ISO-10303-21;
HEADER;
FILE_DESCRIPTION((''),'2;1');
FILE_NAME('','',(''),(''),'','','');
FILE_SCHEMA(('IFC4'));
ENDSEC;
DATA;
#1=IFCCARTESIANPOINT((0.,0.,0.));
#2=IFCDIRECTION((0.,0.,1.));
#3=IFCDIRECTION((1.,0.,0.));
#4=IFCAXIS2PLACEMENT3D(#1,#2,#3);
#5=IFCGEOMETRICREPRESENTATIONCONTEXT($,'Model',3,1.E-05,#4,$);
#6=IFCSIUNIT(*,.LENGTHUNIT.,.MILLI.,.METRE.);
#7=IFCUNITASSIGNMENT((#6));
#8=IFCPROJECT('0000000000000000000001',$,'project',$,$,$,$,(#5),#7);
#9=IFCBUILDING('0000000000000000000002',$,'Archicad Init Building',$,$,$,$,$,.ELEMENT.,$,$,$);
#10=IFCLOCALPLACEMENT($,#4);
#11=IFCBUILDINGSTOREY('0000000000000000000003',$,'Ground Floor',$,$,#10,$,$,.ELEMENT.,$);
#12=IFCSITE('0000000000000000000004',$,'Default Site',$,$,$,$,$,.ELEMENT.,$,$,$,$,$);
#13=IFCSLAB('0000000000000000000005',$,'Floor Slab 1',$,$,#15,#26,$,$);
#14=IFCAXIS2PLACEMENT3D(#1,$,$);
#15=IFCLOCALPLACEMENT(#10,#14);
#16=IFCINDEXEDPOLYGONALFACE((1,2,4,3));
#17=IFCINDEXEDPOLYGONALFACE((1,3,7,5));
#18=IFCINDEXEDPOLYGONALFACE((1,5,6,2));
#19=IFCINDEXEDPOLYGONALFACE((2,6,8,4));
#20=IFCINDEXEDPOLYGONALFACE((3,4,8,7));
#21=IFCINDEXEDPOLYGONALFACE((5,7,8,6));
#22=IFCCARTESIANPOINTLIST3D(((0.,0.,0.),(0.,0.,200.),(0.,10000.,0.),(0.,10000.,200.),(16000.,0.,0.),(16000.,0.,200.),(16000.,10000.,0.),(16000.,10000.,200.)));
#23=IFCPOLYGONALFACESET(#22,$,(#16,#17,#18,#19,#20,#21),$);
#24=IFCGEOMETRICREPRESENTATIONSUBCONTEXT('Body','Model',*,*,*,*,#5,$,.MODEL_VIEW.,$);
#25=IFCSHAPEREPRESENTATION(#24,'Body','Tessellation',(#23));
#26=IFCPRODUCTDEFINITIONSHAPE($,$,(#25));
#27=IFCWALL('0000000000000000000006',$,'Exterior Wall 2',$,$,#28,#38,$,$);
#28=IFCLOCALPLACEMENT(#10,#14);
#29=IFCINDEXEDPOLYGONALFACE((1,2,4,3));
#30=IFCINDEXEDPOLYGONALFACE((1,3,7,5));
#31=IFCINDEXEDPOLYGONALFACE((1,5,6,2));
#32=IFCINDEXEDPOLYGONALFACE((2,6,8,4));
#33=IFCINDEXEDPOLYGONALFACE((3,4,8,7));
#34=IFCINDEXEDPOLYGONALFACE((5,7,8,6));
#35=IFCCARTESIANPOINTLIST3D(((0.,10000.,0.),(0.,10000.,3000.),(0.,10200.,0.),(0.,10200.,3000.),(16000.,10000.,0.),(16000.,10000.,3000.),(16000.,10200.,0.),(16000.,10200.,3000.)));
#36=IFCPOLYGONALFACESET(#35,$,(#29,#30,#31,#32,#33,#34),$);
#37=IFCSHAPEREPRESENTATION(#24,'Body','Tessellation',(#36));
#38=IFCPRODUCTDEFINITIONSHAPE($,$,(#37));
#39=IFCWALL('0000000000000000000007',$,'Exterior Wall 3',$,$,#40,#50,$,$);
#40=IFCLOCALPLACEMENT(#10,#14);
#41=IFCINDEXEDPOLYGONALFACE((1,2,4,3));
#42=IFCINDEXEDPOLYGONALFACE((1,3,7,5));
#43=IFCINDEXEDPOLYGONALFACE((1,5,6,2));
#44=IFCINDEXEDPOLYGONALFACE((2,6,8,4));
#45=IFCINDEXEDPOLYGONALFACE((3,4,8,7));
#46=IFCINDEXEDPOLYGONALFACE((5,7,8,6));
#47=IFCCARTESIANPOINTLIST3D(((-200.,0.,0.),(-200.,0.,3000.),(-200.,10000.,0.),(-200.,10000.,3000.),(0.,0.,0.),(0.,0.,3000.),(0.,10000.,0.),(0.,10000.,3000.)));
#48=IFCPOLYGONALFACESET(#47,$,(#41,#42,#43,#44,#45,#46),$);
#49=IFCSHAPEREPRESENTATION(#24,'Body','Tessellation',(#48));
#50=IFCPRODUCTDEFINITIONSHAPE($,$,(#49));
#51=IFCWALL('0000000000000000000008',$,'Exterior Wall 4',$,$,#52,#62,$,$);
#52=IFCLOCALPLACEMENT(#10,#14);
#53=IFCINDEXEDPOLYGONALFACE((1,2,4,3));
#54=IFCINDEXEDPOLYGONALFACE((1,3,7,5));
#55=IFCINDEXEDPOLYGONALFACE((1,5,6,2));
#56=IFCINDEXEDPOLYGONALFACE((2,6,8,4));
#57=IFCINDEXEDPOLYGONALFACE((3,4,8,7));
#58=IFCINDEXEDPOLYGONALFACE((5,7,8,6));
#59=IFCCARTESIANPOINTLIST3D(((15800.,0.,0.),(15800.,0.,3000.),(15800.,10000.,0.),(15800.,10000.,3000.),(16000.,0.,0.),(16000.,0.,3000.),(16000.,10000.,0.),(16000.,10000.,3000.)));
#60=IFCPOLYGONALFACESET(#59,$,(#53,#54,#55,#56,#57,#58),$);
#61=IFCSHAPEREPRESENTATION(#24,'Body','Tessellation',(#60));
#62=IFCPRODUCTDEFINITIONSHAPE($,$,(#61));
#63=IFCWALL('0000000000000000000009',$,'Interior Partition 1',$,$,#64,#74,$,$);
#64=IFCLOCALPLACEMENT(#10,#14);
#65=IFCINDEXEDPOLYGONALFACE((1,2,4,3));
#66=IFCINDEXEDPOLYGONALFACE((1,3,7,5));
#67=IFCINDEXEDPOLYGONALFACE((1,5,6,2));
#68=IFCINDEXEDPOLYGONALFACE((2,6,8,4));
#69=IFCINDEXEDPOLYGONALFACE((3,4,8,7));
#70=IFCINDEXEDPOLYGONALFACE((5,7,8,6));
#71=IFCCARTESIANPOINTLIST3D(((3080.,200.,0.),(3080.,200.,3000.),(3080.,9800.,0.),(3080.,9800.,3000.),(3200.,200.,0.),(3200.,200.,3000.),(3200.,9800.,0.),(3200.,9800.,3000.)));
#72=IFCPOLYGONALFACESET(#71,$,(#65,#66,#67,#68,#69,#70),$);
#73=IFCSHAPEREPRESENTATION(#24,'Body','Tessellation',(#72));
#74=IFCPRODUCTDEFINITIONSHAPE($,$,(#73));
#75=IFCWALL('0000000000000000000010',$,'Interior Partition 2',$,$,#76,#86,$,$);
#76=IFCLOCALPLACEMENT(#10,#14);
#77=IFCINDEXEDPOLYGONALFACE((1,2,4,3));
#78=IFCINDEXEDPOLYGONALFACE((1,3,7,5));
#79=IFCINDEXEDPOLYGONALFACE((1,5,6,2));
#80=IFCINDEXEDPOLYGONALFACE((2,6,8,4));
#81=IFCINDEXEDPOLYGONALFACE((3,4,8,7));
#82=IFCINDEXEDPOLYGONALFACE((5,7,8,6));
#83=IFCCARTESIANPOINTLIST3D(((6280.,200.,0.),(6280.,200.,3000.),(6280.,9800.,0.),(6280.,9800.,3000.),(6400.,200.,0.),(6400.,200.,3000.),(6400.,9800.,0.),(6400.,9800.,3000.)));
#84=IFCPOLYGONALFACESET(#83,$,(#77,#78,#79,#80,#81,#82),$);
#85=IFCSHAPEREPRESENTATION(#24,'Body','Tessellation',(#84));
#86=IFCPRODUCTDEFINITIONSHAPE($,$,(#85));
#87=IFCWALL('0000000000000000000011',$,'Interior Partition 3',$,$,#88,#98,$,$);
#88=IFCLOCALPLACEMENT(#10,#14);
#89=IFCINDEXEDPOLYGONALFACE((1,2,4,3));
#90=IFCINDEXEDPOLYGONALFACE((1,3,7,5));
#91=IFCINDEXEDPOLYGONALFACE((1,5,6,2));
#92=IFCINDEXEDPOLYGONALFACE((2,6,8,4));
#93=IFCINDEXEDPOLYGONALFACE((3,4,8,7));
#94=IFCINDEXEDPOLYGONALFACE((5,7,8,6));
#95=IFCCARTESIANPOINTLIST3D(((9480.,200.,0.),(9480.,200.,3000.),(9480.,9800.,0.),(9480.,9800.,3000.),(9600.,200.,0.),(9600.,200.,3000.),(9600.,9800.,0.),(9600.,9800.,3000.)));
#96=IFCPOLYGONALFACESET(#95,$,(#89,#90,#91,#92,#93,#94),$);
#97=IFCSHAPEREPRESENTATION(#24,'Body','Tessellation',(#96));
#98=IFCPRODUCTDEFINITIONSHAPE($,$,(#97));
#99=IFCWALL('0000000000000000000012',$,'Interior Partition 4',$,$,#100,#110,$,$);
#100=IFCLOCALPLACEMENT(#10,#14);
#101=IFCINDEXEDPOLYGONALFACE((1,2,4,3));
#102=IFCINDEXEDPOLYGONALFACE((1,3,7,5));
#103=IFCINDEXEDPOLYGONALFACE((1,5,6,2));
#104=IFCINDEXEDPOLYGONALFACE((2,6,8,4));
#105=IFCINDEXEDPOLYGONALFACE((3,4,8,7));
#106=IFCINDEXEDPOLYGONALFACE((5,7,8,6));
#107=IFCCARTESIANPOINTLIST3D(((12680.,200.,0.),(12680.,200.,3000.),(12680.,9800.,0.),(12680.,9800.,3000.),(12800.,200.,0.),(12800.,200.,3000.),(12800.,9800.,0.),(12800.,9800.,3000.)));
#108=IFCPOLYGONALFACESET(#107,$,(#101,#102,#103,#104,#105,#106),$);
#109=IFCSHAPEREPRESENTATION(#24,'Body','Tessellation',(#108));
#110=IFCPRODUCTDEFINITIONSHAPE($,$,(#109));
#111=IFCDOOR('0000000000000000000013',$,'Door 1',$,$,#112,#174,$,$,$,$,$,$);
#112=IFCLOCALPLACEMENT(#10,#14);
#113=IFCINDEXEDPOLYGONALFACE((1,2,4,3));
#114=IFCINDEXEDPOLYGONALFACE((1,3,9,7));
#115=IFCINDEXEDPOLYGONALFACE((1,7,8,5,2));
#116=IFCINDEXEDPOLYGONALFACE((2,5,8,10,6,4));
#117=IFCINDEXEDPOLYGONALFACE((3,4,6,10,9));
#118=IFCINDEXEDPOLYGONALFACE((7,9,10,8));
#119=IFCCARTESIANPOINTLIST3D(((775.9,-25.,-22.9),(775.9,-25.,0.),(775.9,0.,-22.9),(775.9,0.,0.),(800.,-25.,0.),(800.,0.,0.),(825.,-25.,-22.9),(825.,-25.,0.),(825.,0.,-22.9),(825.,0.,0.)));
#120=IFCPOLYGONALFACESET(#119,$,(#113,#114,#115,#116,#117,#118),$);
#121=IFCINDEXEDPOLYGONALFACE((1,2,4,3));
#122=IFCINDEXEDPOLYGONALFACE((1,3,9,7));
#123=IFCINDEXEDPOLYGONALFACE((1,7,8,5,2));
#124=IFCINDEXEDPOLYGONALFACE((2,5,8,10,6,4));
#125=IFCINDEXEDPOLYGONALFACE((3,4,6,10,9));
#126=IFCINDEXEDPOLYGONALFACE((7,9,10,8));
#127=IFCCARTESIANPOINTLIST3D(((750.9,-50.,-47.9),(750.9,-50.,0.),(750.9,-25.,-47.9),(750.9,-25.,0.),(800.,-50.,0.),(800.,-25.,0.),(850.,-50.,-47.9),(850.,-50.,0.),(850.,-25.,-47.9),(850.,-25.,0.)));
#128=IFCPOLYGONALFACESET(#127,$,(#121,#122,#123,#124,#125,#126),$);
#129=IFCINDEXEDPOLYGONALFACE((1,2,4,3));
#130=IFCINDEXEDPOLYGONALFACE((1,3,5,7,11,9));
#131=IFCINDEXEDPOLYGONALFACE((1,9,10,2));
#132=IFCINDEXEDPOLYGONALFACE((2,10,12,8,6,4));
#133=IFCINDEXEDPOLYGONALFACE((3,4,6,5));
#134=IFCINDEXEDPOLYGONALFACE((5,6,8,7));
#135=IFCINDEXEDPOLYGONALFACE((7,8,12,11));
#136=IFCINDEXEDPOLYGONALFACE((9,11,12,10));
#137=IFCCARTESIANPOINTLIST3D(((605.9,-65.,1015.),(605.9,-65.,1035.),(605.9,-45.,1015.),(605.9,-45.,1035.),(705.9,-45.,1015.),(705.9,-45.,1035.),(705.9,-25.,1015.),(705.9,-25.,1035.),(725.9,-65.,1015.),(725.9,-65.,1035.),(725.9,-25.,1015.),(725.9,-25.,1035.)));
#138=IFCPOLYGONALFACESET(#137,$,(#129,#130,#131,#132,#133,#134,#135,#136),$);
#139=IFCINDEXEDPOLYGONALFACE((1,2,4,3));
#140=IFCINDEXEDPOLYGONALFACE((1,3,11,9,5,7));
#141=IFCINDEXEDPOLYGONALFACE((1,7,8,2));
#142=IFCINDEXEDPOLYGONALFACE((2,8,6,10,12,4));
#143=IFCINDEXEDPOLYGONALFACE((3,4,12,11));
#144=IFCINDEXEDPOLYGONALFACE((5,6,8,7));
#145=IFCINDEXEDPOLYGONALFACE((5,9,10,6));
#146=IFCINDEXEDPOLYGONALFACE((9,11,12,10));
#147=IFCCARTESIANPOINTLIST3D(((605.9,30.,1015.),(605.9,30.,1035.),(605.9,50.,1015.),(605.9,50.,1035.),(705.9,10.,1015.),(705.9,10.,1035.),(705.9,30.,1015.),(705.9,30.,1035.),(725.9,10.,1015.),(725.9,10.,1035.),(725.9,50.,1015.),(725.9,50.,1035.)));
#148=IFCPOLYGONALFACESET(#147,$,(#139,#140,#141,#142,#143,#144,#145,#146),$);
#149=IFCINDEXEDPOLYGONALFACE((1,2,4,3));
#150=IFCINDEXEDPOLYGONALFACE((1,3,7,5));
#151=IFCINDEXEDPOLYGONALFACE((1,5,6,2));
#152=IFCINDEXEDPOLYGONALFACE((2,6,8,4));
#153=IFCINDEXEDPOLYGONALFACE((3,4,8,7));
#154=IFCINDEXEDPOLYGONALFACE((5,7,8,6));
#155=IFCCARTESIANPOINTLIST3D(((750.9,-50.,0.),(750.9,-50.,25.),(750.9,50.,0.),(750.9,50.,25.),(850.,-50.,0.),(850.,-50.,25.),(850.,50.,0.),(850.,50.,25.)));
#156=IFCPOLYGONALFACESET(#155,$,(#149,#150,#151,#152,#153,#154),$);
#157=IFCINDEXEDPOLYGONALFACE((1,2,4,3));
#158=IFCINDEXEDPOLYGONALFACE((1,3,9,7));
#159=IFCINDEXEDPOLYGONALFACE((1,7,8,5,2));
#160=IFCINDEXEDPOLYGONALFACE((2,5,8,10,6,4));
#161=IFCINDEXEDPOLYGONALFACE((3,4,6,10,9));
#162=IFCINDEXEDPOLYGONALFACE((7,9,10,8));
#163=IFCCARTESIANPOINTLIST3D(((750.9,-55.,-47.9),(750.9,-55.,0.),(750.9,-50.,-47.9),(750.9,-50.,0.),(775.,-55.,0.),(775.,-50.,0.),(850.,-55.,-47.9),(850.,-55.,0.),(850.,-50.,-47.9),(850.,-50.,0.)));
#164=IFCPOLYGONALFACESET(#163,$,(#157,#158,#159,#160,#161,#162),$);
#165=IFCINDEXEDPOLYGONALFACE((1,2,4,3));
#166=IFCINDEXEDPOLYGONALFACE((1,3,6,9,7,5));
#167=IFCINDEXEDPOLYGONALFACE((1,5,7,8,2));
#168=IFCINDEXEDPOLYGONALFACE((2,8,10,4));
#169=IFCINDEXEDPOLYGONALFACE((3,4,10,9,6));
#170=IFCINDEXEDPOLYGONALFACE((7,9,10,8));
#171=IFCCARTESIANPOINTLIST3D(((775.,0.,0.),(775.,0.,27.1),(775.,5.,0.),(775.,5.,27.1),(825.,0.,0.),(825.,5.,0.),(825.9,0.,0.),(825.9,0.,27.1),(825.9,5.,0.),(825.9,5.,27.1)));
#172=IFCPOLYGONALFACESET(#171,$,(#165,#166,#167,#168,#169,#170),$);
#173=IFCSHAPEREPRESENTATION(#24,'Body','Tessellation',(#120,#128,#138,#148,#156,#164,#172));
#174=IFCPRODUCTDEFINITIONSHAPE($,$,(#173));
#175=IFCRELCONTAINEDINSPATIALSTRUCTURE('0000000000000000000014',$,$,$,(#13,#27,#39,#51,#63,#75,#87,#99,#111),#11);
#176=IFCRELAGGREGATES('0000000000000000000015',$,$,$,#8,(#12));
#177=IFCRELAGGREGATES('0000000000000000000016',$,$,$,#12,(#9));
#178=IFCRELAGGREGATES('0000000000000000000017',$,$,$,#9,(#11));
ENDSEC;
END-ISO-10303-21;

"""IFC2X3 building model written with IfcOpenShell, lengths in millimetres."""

from ifc_helpers import new_model, si_unit, frame, origin_with_axes, place, context, subcontext, project, spatial, polyline, outline, extrude, element, save


model = new_model("IFC2X3")

# Units and contexts
model_context = context("Model", 3, precision=1e-05, world=origin_with_axes())
body_context = subcontext(model_context, "Body", "Model", "MODEL_VIEW")
ifc_project = project(units=[si_unit("LENGTHUNIT", "METRE", prefix="MILLI")], contexts=[model_context])

# Site, building, storey
site = spatial("IfcSite", under=ifc_project, Name="Default Site", CompositionType="ELEMENT")
building = spatial("IfcBuilding", under=site, Name="Archicad Init Building", CompositionType="ELEMENT")
storey_placement = place(None, origin_with_axes())
storey = spatial("IfcBuildingStorey", under=building, at=storey_placement, Name="Ground Floor", CompositionType="ELEMENT")

# Slab
slab_placement = place(storey_placement, origin_with_axes())
element("IfcSlab", 1, at=slab_placement, inside=storey, Name="Floor Slab 1", context=body_context, shape_type="SweptSolid", body=[
    extrude(outline(polyline([(0.0, 0.0), (16000.0, 0.0), (16000.0, 10000.0), (0.0, 10000.0), (0.0, 0.0)])), origin_with_axes(), (0.0, 0.0, 1.0), 200.0),
])

# Walls
wall_placement = place(storey_placement, frame((0.0, 10000.0, 0.0), z_axis=(0.0, 0.0, 1.0), x_axis=(1.0, 0.0, 0.0)))
element("IfcWall", 2, at=wall_placement, inside=storey, Name="Exterior Wall 2", context=body_context, shape_type="SweptSolid", body=[
    extrude(outline(polyline([(0.0, 0.0), (0.0, 200.0), (16000.0, 200.0), (16000.0, 0.0), (0.0, 0.0)])), origin_with_axes(), (0.0, 0.0, 1.0), 3000.0),
])
for number, where, z_axis, x_axis, name in (
    (3, (0.0, 0.0, 0.0), (0.0, 0.0, 1.0), (0.0, 1.0, 0.0), "Exterior Wall 3"),
    (4, (16000.0, 0.0, 0.0), (0.0, 0.0, 1.0), (0.0, 1.0, 0.0), "Exterior Wall 4"),
):
    element("IfcWall", number, at=place(storey_placement, frame(where, z_axis=z_axis, x_axis=x_axis)), inside=storey, Name=name, context=body_context, shape_type="SweptSolid", body=[
        extrude(outline(polyline([(0.0, 0.0), (0.0, 200.0), (10000.0, 200.0), (10000.0, 0.0), (0.0, 0.0)])), origin_with_axes(), (0.0, 0.0, 1.0), 3000.0),
    ])
for number, where, z_axis, x_axis, name in (
    (5, (3200.0, 200.0, 0.0), (0.0, 0.0, 1.0), (0.0, 1.0, 0.0), "Interior Partition 1"),
    (6, (6400.0, 200.0, 0.0), (0.0, 0.0, 1.0), (0.0, 1.0, 0.0), "Interior Partition 2"),
    (7, (9600.0, 200.0, 0.0), (0.0, 0.0, 1.0), (0.0, 1.0, 0.0), "Interior Partition 3"),
    (8, (12800.0, 200.0, 0.0), (0.0, 0.0, 1.0), (0.0, 1.0, 0.0), "Interior Partition 4"),
):
    element("IfcWall", number, at=place(storey_placement, frame(where, z_axis=z_axis, x_axis=x_axis)), inside=storey, Name=name, context=body_context, shape_type="SweptSolid", body=[
        extrude(outline(polyline([(0.0, 0.0), (0.0, 120.0), (9600.0, 120.0), (9600.0, 0.0), (0.0, 0.0)])), origin_with_axes(), (0.0, 0.0, 1.0), 3000.0),
    ])

# Door
door_1_placement = place(storey_placement, frame((800.0, -50.0, 0.0), z_axis=(0.0, 0.0, 1.0), x_axis=(1.0, 0.0, 0.0)))
element("IfcDoor", 9, at=door_1_placement, inside=storey, Name="Door 1", context=body_context, shape_type="SweptSolid", body=[
    extrude(outline(polyline([(0.0, 0.0), (0.0, 2.1), (0.9, 2.1), (0.9, 0.0), (-24.1, 0.0), (-24.1, -22.9), (25.0, -22.9), (25.0, 0.0), (0.0, 0.0)])), frame((0.0, 25.0, 0.0), z_axis=(0.0, -1.0, 0.0), x_axis=(1.0, 0.0, 0.0)), (0.0, 0.0, -1.0), 25.0),
    extrude(outline(polyline([(0.0, 0.0), (0.0, 2.1), (0.9, 2.1), (0.9, 0.0), (-49.1, 0.0), (-49.1, -47.9), (50.0, -47.9), (50.0, 0.0), (0.0, 0.0)])), frame((0.0, 0.0, 0.0), z_axis=(0.0, -1.0, 0.0), x_axis=(1.0, 0.0, 0.0)), (0.0, 0.0, -1.0), 25.0),
    extrude(outline(polyline([(0.0, 0.0), (-49.1, 0.0), (-49.1, 35.0), (0.0, 35.0), (0.0, 0.0)])), frame((25.0, 25.0, 25.0), z_axis=(0.0, 0.0, 1.0), x_axis=(1.0, 0.0, 0.0)), (0.0, 0.0, 1.0), -47.9),
    extrude(outline(polyline([(0.0, 0.0), (0.0, -40.0), (-120.0, -40.0), (-120.0, -20.0), (-20.0, -20.0), (-20.0, 0.0), (0.0, 0.0)])), frame((-74.1, 25.0, 1015.0), z_axis=(0.0, 0.0, 1.0), x_axis=(1.0, 0.0, 0.0)), (0.0, 0.0, 1.0), 20.0),
    extrude(outline(polyline([(0.0, 0.0), (0.0, 40.0), (-120.0, 40.0), (-120.0, 20.0), (-20.0, 20.0), (-20.0, 0.0), (0.0, 0.0)])), frame((-74.1, 60.0, 1015.0), z_axis=(0.0, 0.0, 1.0), x_axis=(1.0, 0.0, 0.0)), (0.0, 0.0, 1.0), 20.0),
    extrude(outline(polyline([(0.0, 0.0), (-99.1, 0.0), (-99.1, 100.0), (0.0, 100.0), (0.0, 0.0)])), frame((50.0, 0.0, 0.0), z_axis=(0.0, 0.0, 1.0), x_axis=(1.0, 0.0, 0.0)), (0.0, 0.0, 1.0), 25.0),
    extrude(outline(polyline([(0.0, 0.0), (0.0, 27.1), (50.9, 27.1), (50.9, 0.0), (-24.1, 0.0), (-24.1, -47.9), (75.0, -47.9), (75.0, 0.0), (0.0, 0.0)])), frame((-25.0, -5.0, 0.0), z_axis=(0.0, -1.0, 0.0), x_axis=(1.0, 0.0, 0.0)), (0.0, 0.0, -1.0), 5.0),
    extrude(outline(polyline([(0.0, 0.0), (0.0, 27.1), (50.9, 27.1), (50.9, 0.0), (0.9, 0.0), (0.9, -22.9), (50.0, -22.9), (50.0, 0.0), (0.0, 0.0)])), frame((-25.0, 50.0, 0.0), z_axis=(0.0, -1.0, 0.0), x_axis=(1.0, 0.0, 0.0)), (0.0, 0.0, -1.0), 5.0),
])

save(model, "model.ifc")
